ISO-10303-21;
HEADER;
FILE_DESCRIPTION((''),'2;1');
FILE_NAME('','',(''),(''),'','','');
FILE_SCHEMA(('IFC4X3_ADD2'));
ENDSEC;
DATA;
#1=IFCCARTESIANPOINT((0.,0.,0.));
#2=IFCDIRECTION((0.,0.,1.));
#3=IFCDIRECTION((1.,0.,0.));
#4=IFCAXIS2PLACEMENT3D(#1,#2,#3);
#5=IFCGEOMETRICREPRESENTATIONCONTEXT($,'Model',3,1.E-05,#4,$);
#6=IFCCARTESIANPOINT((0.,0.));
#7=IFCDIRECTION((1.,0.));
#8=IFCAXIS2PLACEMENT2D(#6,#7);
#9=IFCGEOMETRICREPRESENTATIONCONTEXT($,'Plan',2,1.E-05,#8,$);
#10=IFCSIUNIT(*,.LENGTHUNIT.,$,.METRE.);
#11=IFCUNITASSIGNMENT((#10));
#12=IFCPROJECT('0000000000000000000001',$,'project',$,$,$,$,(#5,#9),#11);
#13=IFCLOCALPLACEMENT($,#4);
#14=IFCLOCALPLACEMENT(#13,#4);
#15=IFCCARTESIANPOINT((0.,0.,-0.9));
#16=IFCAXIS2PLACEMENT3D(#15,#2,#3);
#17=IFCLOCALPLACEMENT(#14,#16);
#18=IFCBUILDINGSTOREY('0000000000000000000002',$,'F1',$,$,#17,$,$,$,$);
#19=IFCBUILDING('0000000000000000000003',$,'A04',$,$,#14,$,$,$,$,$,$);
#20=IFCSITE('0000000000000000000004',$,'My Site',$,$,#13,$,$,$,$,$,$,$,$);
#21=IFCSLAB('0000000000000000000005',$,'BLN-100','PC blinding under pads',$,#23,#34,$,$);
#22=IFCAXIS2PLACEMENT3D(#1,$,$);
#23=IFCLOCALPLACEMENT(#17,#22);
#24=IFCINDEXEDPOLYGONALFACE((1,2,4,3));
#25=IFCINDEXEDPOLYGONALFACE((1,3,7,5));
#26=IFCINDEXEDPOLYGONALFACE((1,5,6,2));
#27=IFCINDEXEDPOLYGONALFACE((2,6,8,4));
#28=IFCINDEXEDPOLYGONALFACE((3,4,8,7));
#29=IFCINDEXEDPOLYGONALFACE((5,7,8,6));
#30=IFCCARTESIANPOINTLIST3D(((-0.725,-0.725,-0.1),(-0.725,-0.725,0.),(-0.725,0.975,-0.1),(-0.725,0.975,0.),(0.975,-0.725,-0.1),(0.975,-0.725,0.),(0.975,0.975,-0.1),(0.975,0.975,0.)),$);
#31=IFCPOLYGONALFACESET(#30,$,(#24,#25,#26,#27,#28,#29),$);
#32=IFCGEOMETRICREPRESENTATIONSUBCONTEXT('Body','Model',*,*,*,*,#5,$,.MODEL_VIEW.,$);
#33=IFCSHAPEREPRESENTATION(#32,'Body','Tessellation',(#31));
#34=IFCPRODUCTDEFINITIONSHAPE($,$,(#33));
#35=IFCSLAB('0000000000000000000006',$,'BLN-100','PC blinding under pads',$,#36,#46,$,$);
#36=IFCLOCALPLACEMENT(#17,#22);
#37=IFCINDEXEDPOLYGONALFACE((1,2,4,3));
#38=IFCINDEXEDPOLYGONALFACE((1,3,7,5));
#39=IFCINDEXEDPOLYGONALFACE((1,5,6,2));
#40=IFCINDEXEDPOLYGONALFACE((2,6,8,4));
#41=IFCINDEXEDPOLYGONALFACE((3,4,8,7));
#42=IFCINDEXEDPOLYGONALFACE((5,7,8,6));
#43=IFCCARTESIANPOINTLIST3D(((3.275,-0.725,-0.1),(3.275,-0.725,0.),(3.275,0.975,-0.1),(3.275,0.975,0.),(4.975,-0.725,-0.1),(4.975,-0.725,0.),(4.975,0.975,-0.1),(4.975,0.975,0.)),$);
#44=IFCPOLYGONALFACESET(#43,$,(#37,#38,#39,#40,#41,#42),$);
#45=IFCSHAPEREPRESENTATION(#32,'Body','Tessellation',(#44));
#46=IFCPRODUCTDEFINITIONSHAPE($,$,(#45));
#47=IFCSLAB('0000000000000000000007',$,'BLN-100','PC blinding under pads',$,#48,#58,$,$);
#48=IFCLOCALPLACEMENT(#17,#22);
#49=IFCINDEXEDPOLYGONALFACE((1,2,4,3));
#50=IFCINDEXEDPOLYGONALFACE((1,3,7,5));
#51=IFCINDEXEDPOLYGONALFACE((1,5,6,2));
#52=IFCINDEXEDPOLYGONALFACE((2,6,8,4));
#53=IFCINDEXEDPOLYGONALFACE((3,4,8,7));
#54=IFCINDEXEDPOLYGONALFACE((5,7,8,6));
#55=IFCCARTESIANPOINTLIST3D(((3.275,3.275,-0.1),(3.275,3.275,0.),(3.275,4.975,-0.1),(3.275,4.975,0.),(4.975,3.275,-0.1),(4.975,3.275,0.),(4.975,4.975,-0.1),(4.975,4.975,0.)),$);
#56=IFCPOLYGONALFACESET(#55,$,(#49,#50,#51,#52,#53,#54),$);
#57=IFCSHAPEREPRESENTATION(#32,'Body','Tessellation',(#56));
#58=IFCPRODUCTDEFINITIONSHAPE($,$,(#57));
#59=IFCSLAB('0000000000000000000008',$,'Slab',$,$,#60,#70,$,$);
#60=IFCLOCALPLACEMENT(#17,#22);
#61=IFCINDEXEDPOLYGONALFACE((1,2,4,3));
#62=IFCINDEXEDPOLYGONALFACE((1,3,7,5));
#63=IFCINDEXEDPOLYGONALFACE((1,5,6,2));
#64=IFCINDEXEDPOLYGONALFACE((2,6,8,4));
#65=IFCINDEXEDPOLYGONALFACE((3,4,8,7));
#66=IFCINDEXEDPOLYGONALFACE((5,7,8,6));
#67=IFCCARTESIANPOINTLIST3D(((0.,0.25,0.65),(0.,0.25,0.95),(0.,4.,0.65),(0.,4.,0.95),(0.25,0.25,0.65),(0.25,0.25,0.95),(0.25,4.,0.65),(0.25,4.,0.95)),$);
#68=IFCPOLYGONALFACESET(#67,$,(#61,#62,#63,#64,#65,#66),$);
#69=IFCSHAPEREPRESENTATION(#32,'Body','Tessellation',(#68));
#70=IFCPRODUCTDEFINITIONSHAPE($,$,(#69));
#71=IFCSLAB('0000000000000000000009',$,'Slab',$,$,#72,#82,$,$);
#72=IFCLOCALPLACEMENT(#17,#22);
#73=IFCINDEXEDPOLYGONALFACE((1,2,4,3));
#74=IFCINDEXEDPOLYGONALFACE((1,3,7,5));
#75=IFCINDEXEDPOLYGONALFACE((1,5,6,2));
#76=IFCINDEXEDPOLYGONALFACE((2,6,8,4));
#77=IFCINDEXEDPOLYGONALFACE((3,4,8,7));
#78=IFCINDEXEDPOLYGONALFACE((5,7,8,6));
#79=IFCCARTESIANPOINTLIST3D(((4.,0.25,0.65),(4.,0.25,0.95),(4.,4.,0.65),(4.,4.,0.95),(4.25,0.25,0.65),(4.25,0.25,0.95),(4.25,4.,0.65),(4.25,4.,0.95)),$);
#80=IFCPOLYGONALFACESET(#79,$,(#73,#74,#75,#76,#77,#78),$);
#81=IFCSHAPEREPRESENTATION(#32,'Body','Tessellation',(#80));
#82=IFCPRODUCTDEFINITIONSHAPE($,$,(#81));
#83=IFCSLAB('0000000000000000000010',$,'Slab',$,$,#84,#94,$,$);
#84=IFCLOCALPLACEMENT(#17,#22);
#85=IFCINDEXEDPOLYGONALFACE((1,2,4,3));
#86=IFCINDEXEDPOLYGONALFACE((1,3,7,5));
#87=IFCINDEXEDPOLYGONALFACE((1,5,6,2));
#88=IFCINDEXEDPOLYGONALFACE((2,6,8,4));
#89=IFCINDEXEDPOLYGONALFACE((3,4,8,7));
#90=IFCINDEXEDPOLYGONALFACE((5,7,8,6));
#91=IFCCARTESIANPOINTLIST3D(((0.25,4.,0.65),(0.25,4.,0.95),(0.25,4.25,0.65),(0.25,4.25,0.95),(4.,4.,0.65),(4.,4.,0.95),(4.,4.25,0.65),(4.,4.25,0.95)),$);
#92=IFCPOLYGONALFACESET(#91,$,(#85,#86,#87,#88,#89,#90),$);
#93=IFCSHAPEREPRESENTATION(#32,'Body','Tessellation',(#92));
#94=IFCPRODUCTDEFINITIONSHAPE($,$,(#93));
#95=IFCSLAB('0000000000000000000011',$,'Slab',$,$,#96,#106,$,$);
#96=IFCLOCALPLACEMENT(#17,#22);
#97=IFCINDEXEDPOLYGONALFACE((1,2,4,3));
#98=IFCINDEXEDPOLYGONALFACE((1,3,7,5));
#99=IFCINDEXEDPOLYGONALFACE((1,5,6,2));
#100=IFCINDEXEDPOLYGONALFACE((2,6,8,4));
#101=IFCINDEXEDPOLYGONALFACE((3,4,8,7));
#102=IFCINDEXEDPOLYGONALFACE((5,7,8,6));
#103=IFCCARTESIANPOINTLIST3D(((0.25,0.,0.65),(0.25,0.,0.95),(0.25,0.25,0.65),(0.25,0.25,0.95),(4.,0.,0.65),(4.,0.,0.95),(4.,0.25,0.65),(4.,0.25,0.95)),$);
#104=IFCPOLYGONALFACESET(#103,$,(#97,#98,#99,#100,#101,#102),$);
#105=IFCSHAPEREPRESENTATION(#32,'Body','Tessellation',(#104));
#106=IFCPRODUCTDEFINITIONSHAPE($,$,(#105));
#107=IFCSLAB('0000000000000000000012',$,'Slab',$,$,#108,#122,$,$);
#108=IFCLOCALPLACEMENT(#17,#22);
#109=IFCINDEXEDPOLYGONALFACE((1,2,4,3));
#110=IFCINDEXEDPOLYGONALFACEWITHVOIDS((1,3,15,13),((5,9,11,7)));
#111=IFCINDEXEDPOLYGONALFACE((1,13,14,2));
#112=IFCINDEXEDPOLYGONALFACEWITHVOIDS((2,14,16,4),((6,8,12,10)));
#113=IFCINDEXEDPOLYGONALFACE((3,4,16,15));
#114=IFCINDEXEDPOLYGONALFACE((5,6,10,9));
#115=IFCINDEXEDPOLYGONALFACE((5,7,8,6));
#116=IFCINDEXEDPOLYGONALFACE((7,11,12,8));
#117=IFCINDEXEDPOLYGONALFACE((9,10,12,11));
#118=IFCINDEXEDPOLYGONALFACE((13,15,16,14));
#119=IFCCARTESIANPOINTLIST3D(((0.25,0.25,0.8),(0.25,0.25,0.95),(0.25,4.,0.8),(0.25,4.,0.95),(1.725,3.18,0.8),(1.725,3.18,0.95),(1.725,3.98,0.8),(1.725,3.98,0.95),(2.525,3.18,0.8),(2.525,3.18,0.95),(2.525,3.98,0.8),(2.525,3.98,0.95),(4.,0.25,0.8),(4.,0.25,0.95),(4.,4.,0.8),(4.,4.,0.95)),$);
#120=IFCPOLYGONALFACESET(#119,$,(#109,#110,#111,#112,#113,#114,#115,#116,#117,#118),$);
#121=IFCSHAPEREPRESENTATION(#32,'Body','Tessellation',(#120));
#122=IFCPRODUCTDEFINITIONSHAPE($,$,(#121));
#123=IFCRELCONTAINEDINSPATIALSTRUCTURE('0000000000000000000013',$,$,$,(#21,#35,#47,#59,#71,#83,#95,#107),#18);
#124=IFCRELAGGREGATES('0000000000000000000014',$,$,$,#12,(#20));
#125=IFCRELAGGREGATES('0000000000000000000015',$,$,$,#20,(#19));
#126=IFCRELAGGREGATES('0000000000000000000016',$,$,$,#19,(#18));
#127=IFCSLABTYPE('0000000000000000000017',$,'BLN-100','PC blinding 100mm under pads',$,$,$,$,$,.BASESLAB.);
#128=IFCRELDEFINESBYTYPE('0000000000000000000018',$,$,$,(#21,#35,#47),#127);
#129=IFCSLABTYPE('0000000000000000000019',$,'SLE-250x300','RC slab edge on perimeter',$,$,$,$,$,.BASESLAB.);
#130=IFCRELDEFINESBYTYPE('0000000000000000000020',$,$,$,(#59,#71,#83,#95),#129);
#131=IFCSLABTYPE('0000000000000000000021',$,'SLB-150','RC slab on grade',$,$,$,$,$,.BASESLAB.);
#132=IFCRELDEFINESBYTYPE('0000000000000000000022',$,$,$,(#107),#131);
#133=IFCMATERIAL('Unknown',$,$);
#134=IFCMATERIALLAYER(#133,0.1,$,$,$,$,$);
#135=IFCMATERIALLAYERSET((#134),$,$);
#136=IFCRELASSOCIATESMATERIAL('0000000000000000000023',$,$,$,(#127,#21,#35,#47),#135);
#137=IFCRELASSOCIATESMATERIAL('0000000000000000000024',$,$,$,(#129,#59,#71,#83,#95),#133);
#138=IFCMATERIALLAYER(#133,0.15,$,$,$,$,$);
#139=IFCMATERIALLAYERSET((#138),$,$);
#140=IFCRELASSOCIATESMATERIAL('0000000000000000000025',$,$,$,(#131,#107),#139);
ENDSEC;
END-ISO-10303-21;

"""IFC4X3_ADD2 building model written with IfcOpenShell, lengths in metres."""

from ifc_helpers import new_model, si_unit, frame, origin_with_axes, origin_2d_with_axis, place, context, subcontext, project, spatial, indexed_curve, rectangle, outline, extrude, material, layer, layer_set, layer_usage, material_profile, profile_set, profile_usage, type_object, element, save


model = new_model("IFC4X3_ADD2")

# Units and contexts
model_context = context("Model", 3, precision=1e-05, world=origin_with_axes())
plan_context = context("Plan", 2, precision=1e-05, world=origin_2d_with_axis())
body_context = subcontext(model_context, "Body", "Model", "MODEL_VIEW")
ifc_project = project(units=[si_unit("LENGTHUNIT", "METRE")], contexts=[model_context, plan_context])

# Site, building, storey
site_placement = place(None, origin_with_axes())
site = spatial("IfcSite", under=ifc_project, at=site_placement, Name="My Site")
building_placement = place(site_placement, origin_with_axes())
building = spatial("IfcBuilding", under=site, at=building_placement, Name="A04")
storey_placement = place(building_placement, frame((0.0, 0.0, -0.9), z_axis=(0.0, 0.0, 1.0), x_axis=(1.0, 0.0, 0.0)))
storey = spatial("IfcBuildingStorey", under=building, at=storey_placement, Name="F1")

# Shared definitions
ifc_material_1 = material(Name="Unknown")

# Slabs
ifc_layer_1 = layer(ifc_material_1, 0.1)
ifc_layer_set_1 = layer_set([ifc_layer_1])
slab_type_1 = type_object("IfcSlabType", Name="BLN-100", Description="PC blinding 100mm under pads", PredefinedType="BASESLAB", material=ifc_layer_set_1)
ifc_layer_usage_1 = layer_usage(ifc_layer_set_1, "AXIS3", "POSITIVE", -0.1)
slab_1_placement = place(storey_placement, frame((-0.725, 0.975, 0.0), z_axis=(0.0, 0.0, 1.0), x_axis=(1.0, 0.0, 0.0)))
element("IfcSlab", 1, at=slab_1_placement, inside=storey, type_object=slab_type_1, material=ifc_layer_usage_1, Name="BLN-100", Description="PC blinding under pads", context=body_context, shape_type="SweptSolid", body=[
    extrude(outline(indexed_curve([(0.0, 0.0), (1.7, 0.0), (1.7, -1.7), (0.0, -1.7), (0.0, 0.0)])), frame((0.0, 0.0, -0.1), z_axis=(0.0, 0.0, 1.0), x_axis=(1.0, 0.0, 0.0)), (0.0, 0.0, 1.0), 0.1),
])
ifc_layer_usage_2 = layer_usage(ifc_layer_set_1, "AXIS3", "POSITIVE", -0.1)
slab_2_placement = place(storey_placement, frame((3.275, 0.975, 0.0), z_axis=(0.0, 0.0, 1.0), x_axis=(1.0, 0.0, 0.0)))
element("IfcSlab", 2, at=slab_2_placement, inside=storey, type_object=slab_type_1, material=ifc_layer_usage_2, Name="BLN-100", Description="PC blinding under pads", context=body_context, shape_type="SweptSolid", body=[
    extrude(outline(indexed_curve([(0.0, 0.0), (1.7, 0.0), (1.7, -1.7), (0.0, -1.7), (0.0, 0.0)])), frame((0.0, 0.0, -0.1), z_axis=(0.0, 0.0, 1.0), x_axis=(1.0, 0.0, 0.0)), (0.0, 0.0, 1.0), 0.1),
])
ifc_layer_usage_3 = layer_usage(ifc_layer_set_1, "AXIS3", "POSITIVE", -0.1)
slab_3_placement = place(storey_placement, frame((3.275, 4.975, 0.0), z_axis=(0.0, 0.0, 1.0), x_axis=(1.0, 0.0, 0.0)))
element("IfcSlab", 3, at=slab_3_placement, inside=storey, type_object=slab_type_1, material=ifc_layer_usage_3, Name="BLN-100", Description="PC blinding under pads", context=body_context, shape_type="SweptSolid", body=[
    extrude(outline(indexed_curve([(0.0, 0.0), (1.7, 0.0), (1.7, -1.7), (0.0, -1.7), (0.0, 0.0)])), frame((0.0, 0.0, -0.1), z_axis=(0.0, 0.0, 1.0), x_axis=(1.0, 0.0, 0.0)), (0.0, 0.0, 1.0), 0.1),
])
ifc_material_profile_1 = material_profile(ifc_material_1, rectangle(XDim=0.25, YDim=0.3))
ifc_profile_set_1 = profile_set([ifc_material_profile_1])
ifc_profile_usage_1 = profile_usage(ifc_profile_set_1, cardinal=7)
slab_type_2 = type_object("IfcSlabType", Name="SLE-250x300", Description="RC slab edge on perimeter", PredefinedType="BASESLAB", material=ifc_profile_set_1)
slab_4_placement = place(storey_placement, frame((0.0, 0.25, 0.95), z_axis=(0.0, 1.0, 0.0), x_axis=(-1.0, 0.0, 0.0)))
element("IfcSlab", 4, at=slab_4_placement, inside=storey, type_object=slab_type_2, material=ifc_profile_usage_1, Name="Slab", context=body_context, shape_type="SweptSolid", body=[
    extrude(rectangle(XDim=0.25, YDim=0.3), frame((-0.125, -0.15, 0.0), z_axis=(0.0, 0.0, 1.0), x_axis=(1.0, 0.0, 0.0)), (0.0, 0.0, 1.0), 3.75),
])
ifc_profile_usage_2 = profile_usage(ifc_profile_set_1, cardinal=7)
slab_5_placement = place(storey_placement, frame((4.25, 4.0, 0.95), z_axis=(0.0, -1.0, 0.0), x_axis=(1.0, 0.0, 0.0)))
element("IfcSlab", 5, at=slab_5_placement, inside=storey, type_object=slab_type_2, material=ifc_profile_usage_2, Name="Slab", context=body_context, shape_type="SweptSolid", body=[
    extrude(rectangle(XDim=0.25, YDim=0.3), frame((-0.125, -0.15, 0.0), z_axis=(0.0, 0.0, 1.0), x_axis=(1.0, 0.0, 0.0)), (0.0, 0.0, 1.0), 3.75),
])
ifc_profile_usage_3 = profile_usage(ifc_profile_set_1, cardinal=7)
slab_6_placement = place(storey_placement, frame((0.25, 4.25, 0.95), z_axis=(1.0, 0.0, 0.0), x_axis=(0.0, 1.0, 0.0)))
element("IfcSlab", 6, at=slab_6_placement, inside=storey, type_object=slab_type_2, material=ifc_profile_usage_3, Name="Slab", context=body_context, shape_type="SweptSolid", body=[
    extrude(rectangle(XDim=0.25, YDim=0.3), frame((-0.125, -0.15, 0.0), z_axis=(0.0, 0.0, 1.0), x_axis=(1.0, 0.0, 0.0)), (0.0, 0.0, 1.0), 3.75),
])
ifc_profile_usage_4 = profile_usage(ifc_profile_set_1, cardinal=7)
slab_7_placement = place(storey_placement, frame((0.25, 0.25, 0.95), z_axis=(1.0, 0.0, 0.0), x_axis=(0.0, 1.0, 0.0)))
element("IfcSlab", 7, at=slab_7_placement, inside=storey, type_object=slab_type_2, material=ifc_profile_usage_4, Name="Slab", context=body_context, shape_type="SweptSolid", body=[
    extrude(rectangle(XDim=0.25, YDim=0.3), frame((-0.125, -0.15, 0.0), z_axis=(0.0, 0.0, 1.0), x_axis=(1.0, 0.0, 0.0)), (0.0, 0.0, 1.0), 3.75),
])

# Slab, opening
ifc_layer_2 = layer(ifc_material_1, 0.15)
ifc_layer_set_2 = layer_set([ifc_layer_2])
ifc_layer_usage_4 = layer_usage(ifc_layer_set_2, "AXIS3", "POSITIVE", -0.15)
slab_type_3 = type_object("IfcSlabType", Name="SLB-150", Description="RC slab on grade", PredefinedType="BASESLAB", material=ifc_layer_set_2)
slab_8_placement = place(storey_placement, frame((0.25, 0.25, 0.95), z_axis=(0.0, 0.0, 1.0), x_axis=(1.0, 0.0, 0.0)))
slab_8 = element("IfcSlab", 8, at=slab_8_placement, inside=storey, type_object=slab_type_3, material=ifc_layer_usage_4, Name="Slab", context=body_context, shape_type="SweptSolid", body=[
    extrude(outline(indexed_curve([(3.75, 0.0), (3.75, 3.75), (0.0, 3.75), (0.0, 0.0), (3.75, 0.0)])), frame((0.0, 0.0, -0.15), z_axis=(0.0, 0.0, 1.0), x_axis=(1.0, 0.0, 0.0)), (0.0, 0.0, 1.0), 0.15),
])
opening_1_placement = place(slab_8_placement, frame((1.625, 3.08, -0.15), z_axis=(0.0, 0.0, 1.0), x_axis=(1.0, 0.0, 0.0)))
element("IfcOpeningElement", 9, at=opening_1_placement, cuts=slab_8, PredefinedType="OPENING", context=body_context, shape_type="SweptSolid", body=[
    extrude(outline(indexed_curve([(-0.15, -0.15), (0.65, -0.15), (0.65, 0.65), (-0.15, 0.65), (-0.15, -0.15)])), origin_with_axes(), (0.0, 0.0, 1.0), 0.15),
])

save(model, "model.ifc")
